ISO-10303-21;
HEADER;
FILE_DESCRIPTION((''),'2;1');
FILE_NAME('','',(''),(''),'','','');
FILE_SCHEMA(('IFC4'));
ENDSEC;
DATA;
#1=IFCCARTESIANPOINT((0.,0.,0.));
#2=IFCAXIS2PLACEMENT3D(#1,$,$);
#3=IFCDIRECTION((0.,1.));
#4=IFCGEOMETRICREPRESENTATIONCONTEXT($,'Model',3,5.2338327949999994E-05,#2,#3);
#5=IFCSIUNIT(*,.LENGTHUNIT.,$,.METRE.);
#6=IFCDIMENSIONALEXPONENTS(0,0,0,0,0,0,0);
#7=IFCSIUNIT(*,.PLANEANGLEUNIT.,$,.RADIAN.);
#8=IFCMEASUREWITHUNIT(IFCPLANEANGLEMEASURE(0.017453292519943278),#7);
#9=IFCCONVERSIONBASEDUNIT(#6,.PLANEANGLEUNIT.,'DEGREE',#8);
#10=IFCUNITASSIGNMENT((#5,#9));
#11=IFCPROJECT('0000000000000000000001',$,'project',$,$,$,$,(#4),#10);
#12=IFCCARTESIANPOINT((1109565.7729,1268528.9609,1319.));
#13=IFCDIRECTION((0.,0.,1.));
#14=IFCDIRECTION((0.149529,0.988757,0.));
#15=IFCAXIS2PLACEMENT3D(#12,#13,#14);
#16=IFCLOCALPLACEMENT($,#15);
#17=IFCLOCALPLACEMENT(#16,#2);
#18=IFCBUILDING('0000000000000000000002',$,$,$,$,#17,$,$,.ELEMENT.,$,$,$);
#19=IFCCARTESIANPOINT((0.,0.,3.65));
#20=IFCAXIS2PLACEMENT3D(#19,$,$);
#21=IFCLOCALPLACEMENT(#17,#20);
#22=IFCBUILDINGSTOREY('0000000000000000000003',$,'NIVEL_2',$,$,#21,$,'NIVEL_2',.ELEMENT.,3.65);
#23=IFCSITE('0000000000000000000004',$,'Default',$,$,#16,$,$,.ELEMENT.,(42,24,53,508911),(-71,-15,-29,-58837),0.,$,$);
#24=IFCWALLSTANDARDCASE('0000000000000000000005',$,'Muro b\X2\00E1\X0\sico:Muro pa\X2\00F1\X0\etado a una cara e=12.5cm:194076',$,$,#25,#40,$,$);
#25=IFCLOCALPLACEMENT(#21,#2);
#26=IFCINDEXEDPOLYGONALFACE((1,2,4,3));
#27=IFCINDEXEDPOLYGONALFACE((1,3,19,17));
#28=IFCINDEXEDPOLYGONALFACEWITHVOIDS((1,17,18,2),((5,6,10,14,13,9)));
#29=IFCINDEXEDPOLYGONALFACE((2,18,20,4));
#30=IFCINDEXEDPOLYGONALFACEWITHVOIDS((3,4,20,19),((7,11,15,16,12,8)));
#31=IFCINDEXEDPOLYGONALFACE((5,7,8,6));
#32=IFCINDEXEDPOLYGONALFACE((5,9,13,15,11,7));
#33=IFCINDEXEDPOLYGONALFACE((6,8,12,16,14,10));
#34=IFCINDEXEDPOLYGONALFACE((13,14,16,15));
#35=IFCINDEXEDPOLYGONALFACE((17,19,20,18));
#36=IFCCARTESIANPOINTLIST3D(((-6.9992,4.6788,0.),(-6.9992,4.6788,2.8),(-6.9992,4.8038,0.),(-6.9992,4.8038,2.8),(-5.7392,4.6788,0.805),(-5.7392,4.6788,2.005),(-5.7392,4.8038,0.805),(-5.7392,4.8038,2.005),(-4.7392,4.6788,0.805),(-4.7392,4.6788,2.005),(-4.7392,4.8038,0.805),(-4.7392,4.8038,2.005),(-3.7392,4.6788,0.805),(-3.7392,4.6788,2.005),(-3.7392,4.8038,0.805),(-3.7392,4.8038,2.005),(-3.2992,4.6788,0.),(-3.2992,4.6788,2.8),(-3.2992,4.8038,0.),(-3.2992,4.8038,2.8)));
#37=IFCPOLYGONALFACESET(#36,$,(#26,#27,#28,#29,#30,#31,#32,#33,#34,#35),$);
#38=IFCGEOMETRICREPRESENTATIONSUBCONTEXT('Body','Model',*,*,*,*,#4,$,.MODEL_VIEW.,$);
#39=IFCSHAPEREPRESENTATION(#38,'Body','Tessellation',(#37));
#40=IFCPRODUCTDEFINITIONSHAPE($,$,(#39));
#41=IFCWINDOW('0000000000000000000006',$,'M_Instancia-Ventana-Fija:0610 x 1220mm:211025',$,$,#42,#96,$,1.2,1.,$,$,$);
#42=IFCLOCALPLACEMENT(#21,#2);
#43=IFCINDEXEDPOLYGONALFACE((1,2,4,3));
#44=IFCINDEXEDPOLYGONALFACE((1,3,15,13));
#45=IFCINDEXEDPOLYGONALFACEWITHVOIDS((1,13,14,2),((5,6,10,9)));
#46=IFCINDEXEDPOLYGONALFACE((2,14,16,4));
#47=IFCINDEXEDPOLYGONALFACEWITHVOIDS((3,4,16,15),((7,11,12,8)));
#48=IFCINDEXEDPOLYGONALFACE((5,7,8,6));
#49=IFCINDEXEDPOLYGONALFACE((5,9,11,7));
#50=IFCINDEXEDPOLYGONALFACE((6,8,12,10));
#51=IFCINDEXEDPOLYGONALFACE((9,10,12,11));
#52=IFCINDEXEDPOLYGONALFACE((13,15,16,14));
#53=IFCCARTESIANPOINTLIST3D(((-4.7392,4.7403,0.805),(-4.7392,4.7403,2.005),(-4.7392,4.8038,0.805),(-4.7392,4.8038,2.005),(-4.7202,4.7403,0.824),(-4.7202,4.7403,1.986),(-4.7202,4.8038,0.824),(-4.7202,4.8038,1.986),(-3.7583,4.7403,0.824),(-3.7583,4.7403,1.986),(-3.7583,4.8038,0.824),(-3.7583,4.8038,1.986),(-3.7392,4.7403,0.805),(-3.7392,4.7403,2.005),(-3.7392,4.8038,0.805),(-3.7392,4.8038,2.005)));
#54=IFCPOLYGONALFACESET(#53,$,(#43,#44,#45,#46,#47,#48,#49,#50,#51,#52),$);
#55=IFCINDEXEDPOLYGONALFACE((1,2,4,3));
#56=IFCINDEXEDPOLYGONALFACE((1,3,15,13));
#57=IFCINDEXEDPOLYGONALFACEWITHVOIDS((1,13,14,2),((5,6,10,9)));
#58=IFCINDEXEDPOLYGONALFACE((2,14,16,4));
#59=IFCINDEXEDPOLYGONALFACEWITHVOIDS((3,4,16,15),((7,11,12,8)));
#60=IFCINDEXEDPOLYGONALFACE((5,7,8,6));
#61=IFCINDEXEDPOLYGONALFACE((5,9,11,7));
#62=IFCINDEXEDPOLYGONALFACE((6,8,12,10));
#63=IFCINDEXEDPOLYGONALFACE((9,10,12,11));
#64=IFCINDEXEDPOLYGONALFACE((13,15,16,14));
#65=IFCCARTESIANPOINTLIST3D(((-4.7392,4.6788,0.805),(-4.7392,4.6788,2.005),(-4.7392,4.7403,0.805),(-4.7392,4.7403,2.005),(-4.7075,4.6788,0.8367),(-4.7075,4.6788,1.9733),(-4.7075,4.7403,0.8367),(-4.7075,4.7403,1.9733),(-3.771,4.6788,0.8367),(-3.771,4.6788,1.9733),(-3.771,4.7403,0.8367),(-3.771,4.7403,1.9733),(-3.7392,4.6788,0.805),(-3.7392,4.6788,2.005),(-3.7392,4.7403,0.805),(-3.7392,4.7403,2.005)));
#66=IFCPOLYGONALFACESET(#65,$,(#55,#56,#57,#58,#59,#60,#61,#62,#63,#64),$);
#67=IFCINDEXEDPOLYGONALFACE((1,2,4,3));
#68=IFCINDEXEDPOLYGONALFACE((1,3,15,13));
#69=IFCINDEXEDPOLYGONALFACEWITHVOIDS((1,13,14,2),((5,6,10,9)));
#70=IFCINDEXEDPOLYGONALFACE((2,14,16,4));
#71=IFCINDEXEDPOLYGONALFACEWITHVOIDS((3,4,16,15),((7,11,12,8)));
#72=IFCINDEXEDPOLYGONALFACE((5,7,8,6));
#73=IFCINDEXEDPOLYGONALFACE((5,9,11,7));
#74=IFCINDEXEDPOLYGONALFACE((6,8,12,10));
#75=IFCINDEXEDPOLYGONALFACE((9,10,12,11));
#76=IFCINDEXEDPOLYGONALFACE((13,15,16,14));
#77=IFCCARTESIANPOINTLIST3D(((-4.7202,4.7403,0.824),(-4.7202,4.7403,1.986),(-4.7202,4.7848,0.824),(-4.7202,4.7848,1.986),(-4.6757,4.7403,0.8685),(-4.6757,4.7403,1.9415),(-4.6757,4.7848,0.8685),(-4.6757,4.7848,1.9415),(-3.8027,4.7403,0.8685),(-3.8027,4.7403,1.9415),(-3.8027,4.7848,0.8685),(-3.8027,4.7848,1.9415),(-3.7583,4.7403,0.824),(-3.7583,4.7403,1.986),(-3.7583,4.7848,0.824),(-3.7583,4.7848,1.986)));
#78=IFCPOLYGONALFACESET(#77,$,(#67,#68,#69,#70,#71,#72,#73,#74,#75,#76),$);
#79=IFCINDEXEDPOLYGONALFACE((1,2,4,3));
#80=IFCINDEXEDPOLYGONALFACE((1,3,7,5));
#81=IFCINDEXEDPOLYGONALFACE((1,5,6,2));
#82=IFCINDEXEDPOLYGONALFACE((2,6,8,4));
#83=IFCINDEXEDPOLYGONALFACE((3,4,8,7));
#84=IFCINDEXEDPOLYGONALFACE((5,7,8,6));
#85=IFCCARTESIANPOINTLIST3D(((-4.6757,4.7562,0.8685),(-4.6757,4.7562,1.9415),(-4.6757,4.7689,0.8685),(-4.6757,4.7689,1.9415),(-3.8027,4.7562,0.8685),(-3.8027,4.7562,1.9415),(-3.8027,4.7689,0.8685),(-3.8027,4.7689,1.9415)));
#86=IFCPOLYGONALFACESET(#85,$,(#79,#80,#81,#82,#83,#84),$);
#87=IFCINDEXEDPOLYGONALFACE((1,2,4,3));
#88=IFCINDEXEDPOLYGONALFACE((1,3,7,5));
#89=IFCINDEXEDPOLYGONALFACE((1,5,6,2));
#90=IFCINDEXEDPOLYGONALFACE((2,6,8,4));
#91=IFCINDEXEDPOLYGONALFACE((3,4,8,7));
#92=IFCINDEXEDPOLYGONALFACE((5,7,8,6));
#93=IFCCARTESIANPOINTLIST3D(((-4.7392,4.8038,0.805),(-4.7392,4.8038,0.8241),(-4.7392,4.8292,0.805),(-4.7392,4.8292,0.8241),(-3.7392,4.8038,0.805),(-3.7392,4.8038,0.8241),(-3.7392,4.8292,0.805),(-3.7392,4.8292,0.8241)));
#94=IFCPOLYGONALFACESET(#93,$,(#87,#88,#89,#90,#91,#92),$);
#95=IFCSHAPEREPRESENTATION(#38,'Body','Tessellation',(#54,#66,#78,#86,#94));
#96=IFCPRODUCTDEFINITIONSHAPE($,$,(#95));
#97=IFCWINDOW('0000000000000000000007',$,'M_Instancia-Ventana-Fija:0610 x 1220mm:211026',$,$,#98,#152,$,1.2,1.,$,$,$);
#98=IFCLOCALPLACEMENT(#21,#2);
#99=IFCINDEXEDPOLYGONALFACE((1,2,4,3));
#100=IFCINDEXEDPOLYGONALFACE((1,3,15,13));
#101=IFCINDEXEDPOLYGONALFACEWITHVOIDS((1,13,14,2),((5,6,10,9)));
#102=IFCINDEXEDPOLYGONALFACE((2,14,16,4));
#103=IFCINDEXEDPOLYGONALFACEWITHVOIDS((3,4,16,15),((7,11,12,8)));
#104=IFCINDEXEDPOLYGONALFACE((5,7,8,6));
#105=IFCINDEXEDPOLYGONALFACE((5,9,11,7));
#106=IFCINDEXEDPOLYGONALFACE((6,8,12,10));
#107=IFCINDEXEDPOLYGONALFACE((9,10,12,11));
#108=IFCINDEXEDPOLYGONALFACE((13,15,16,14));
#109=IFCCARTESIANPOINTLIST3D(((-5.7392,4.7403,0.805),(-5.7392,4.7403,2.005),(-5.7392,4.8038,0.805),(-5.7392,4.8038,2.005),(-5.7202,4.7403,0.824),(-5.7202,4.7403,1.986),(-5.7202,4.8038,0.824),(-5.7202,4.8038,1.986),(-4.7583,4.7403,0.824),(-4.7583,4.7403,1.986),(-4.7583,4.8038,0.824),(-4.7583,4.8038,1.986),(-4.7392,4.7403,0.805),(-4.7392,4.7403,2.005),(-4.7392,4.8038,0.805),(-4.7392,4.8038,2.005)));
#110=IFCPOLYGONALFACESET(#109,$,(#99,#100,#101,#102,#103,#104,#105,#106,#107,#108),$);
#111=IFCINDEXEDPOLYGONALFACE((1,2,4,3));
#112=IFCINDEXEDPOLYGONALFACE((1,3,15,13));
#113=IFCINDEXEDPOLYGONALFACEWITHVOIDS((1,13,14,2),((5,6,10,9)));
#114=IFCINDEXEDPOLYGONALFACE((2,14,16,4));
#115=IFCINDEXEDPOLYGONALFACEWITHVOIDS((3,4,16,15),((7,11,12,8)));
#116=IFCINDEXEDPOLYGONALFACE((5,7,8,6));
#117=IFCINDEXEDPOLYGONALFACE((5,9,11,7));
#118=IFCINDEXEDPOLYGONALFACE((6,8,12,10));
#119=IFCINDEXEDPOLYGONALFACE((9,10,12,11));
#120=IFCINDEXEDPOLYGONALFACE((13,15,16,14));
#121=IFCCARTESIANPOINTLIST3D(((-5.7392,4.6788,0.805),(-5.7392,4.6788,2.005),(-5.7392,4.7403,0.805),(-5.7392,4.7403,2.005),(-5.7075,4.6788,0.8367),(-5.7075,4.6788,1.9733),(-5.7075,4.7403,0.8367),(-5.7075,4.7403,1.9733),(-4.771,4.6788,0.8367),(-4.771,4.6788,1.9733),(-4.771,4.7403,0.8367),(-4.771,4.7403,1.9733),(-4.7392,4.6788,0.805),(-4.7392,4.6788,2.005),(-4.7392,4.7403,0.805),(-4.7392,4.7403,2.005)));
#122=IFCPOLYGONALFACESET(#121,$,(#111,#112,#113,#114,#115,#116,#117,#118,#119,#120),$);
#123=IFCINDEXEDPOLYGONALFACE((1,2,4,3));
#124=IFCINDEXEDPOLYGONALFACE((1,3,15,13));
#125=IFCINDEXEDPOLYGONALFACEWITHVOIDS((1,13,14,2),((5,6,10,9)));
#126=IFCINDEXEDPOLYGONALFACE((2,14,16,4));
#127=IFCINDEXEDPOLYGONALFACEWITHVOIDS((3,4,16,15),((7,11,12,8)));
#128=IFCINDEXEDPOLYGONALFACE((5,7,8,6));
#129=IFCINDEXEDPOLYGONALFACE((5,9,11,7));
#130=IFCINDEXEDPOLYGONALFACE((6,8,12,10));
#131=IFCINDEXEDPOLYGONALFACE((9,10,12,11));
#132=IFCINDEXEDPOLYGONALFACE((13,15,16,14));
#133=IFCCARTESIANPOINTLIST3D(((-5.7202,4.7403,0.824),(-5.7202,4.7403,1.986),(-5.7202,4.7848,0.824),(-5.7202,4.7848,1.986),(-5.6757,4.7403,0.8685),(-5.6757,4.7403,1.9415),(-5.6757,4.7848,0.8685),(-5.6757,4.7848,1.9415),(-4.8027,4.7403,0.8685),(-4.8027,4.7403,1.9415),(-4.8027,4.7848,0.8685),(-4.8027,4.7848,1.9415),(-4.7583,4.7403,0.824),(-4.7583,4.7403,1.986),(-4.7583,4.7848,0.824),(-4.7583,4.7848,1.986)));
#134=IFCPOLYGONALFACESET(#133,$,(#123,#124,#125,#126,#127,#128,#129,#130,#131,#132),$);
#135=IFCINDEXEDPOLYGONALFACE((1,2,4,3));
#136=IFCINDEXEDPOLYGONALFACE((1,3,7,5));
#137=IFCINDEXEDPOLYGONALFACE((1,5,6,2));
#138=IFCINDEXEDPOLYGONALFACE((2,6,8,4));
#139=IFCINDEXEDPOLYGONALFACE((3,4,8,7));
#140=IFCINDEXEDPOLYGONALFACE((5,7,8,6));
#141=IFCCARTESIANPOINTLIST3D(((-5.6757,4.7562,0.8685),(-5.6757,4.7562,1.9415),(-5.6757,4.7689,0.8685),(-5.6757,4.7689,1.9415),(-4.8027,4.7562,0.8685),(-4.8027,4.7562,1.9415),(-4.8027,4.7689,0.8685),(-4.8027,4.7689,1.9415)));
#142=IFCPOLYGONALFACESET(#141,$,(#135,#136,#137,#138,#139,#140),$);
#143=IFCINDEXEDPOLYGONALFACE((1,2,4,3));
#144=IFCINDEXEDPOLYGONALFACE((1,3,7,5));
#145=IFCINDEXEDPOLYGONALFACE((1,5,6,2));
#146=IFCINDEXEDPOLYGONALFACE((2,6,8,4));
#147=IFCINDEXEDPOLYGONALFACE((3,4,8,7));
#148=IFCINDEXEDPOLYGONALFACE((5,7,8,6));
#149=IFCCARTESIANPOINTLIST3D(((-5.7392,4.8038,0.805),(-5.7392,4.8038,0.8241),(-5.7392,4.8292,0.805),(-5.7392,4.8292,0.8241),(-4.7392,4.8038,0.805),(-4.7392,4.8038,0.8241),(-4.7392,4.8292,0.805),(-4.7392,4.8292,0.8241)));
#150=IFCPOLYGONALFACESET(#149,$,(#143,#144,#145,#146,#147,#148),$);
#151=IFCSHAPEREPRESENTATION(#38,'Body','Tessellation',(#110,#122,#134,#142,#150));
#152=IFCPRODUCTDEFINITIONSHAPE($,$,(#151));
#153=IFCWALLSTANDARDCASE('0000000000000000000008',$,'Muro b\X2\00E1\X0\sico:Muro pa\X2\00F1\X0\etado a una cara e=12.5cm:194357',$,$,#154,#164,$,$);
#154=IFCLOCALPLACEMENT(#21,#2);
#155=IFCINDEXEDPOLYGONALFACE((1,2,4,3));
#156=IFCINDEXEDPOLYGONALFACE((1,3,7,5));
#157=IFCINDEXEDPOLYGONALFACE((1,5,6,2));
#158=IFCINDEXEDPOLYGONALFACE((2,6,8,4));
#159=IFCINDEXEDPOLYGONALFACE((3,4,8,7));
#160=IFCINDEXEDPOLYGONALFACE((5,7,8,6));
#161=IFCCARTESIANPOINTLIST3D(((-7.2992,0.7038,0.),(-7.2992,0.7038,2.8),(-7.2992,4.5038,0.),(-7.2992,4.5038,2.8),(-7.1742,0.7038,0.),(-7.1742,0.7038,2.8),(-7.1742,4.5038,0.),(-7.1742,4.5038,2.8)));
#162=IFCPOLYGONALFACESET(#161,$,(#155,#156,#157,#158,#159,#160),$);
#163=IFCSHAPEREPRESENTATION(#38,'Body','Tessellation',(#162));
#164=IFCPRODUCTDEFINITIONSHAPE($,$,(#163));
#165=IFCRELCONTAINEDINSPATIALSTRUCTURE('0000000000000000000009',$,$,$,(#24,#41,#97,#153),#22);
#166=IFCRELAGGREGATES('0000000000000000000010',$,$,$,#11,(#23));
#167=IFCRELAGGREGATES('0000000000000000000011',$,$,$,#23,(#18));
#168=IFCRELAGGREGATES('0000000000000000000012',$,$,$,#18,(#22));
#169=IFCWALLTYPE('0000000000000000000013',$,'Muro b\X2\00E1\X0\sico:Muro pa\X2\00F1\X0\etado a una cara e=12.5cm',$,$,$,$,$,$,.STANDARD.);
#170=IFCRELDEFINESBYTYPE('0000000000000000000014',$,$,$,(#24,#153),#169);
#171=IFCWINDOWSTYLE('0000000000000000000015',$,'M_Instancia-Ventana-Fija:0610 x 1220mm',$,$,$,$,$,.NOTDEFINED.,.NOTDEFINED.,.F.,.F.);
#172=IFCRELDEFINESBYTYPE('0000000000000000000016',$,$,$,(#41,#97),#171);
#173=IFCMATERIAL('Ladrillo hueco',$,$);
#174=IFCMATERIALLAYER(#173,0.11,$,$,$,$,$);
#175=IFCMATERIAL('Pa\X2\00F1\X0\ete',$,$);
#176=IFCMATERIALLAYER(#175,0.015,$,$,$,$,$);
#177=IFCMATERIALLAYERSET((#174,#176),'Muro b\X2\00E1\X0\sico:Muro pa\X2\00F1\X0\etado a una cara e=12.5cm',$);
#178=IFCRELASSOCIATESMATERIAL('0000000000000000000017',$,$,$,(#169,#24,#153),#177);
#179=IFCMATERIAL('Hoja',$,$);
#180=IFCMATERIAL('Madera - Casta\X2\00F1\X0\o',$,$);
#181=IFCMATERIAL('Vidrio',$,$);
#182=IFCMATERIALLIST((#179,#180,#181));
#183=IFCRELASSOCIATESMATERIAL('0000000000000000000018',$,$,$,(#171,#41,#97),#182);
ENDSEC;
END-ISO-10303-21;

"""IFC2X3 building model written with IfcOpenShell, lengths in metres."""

from ifc_helpers import new_model, entity, si_unit, converted_unit, direction, frame, frame_2d, origin, origin_2d_with_axis, place, context, subcontext, project, spatial, polyline, rectangle, outline, extrude, source, transform, mapped, material, material_list, layer, layer_set, layer_usage, type_object, type_shapes, element, fill, save


model = new_model("IFC2X3")

# Units and contexts
model_context = context("Model", 3, precision=5.2338327949999994e-05, world=origin(), true_north=direction((0.0, 1.0)))
body_context = subcontext(model_context, "Body", "Model", "MODEL_VIEW")
ifc_project = project(units=[si_unit("LENGTHUNIT", "METRE"), converted_unit("PLANEANGLEUNIT", "DEGREE", entity("IfcPlaneAngleMeasure", 0.017453292519943278), si_unit("PLANEANGLEUNIT", "RADIAN"), dimensions=[0, 0, 0, 0, 0, 0, 0])], contexts=[model_context])

# Site, building, storey
site_placement = place(None, frame((1109565.7729, 1268528.9609, 1319.0), z_axis=(0.0, 0.0, 1.0), x_axis=(0.149529, 0.988757, 0.0)))
site = spatial("IfcSite", under=ifc_project, at=site_placement, Name="Default", CompositionType="ELEMENT", RefLatitude=(42, 24, 53, 508911), RefLongitude=(-71, -15, -29, -58837), RefElevation=0.0)
building_placement = place(site_placement, origin())
building = spatial("IfcBuilding", under=site, at=building_placement, CompositionType="ELEMENT")
storey_placement = place(building_placement, frame((0.0, 0.0, 3.65)))
storey = spatial("IfcBuildingStorey", under=building, at=storey_placement, Name="NIVEL_2", LongName="NIVEL_2", CompositionType="ELEMENT", Elevation=3.65)

# Shared definitions
ifc_material_1 = material(Name="Pañete")
ifc_material_2 = material(Name="Ladrillo hueco")

# Wall, openings, windows
ifc_layer_1 = layer(ifc_material_2, 0.11)
ifc_layer_2 = layer(ifc_material_1, 0.015)
ifc_layer_set_1 = layer_set([ifc_layer_1, ifc_layer_2], Name="Muro básico:Muro pañetado a una cara e=12.5cm")
ifc_layer_usage_1 = layer_usage(ifc_layer_set_1, "AXIS2", "NEGATIVE", 0.0625)
wall_type_1 = type_object("IfcWallType", Name="Muro básico:Muro pañetado a una cara e=12.5cm", PredefinedType="STANDARD", material=ifc_layer_set_1)
wall_1_placement = place(storey_placement, frame((-6.9992, 4.7413, 0.0)))
wall_1 = element("IfcWallStandardCase", 1, at=wall_1_placement, inside=storey, type_object=wall_type_1, material=ifc_layer_usage_1, Name="Muro básico:Muro pañetado a una cara e=12.5cm:194076", context=body_context, shape_type="SweptSolid", body=[
    extrude(rectangle(XDim=3.7, YDim=0.125, at=frame_2d((1.85, 0.0), x_axis=(-1.0, 0.0))), origin(), (0.0, 0.0, 1.0), 2.8),
])
opening_1_placement = place(wall_1_placement, frame((1.26, -0.0625, 0.805)))
opening_1 = element("IfcOpeningElement", 2, at=opening_1_placement, cuts=wall_1, ObjectType="Opening", context=body_context, shape_type="SweptSolid", body=[
    extrude(rectangle(XDim=1.2, YDim=1.0, at=frame_2d((0.6, 0.5), x_axis=(-1.0, 0.0))), frame((0.0, 0.0, 0.0), z_axis=(0.0, 1.0, 0.0), x_axis=(0.0, 0.0, 1.0)), (0.0, 0.0, 1.0), 0.125),
])
opening_2_placement = place(wall_1_placement, frame((2.26, -0.0625, 0.805)))
opening_2 = element("IfcOpeningElement", 3, at=opening_2_placement, cuts=wall_1, ObjectType="Opening", context=body_context, shape_type="SweptSolid", body=[
    extrude(rectangle(XDim=1.2, YDim=1.0, at=frame_2d((0.6, 0.5), x_axis=(-1.0, 0.0))), frame((0.0, 0.0, 0.0), z_axis=(0.0, 1.0, 0.0), x_axis=(0.0, 0.0, 1.0)), (0.0, 0.0, 1.0), 0.125),
])
ifc_material_3 = material(Name="Hoja")
ifc_material_4 = material(Name="Madera - Castaño")
ifc_material_5 = material(Name="Vidrio")
ifc_material_list = material_list([ifc_material_3, ifc_material_4, ifc_material_5])
window_style_1 = type_object("IfcWindowStyle", Name="M_Instancia-Ventana-Fija:0610 x 1220mm", ConstructionType="NOTDEFINED", OperationType="NOTDEFINED", ParameterTakesPrecedence=False, Sizeable=False, material=ifc_material_list)
shared_shape_1 = source(origin(), body_context, "Body", "SweptSolid", [
    extrude(outline(polyline([(-0.6, -0.5), (0.6, -0.5), (0.6, 0.5), (-0.6, 0.5), (-0.6, -0.5)]), holes=[polyline([(-0.5809, -0.4809), (-0.5809, 0.481), (0.581, 0.481), (0.581, -0.4809), (-0.5809, -0.4809)])]), frame((0.5, 0.0616, 0.6), z_axis=(0.0, 1.0, 0.0), x_axis=(0.0, 0.0, -1.0)), (0.0, 0.0, 1.0), 0.0635),
    extrude(outline(polyline([(-0.5, -0.6), (0.5, -0.6), (0.5, 0.6), (-0.5, 0.6), (-0.5, -0.6)]), holes=[polyline([(-0.4683, -0.5682), (-0.4683, 0.5683), (0.4682, 0.5683), (0.4682, -0.5682), (-0.4683, -0.5682)])]), frame((0.5, 0.0, 0.6), z_axis=(0.0, 1.0, 0.0), x_axis=(1.0, 0.0, 0.0)), (0.0, 0.0, 1.0), 0.0616),
    extrude(outline(polyline([(-0.4809, -0.581), (0.4809, -0.581), (0.4809, 0.581), (-0.4809, 0.581), (-0.4809, -0.581)]), holes=[polyline([(-0.4365, -0.5365), (-0.4365, 0.5365), (0.4365, 0.5365), (0.4365, -0.5365), (-0.4365, -0.5365)])]), frame((0.5, 0.0616, 0.6), z_axis=(0.0, 1.0, 0.0), x_axis=(1.0, 0.0, 0.0)), (0.0, 0.0, 1.0), 0.0444),
    extrude(rectangle(XDim=0.0127, YDim=0.873, at=origin_2d_with_axis()), frame((0.5, 0.0838, 0.0635), z_axis=(0.0, 0.0, 1.0), x_axis=(0.0, 1.0, 0.0)), (0.0, 0.0, 1.0), 1.073),
    extrude(rectangle(XDim=0.0254, YDim=1.0, at=origin_2d_with_axis()), frame((0.5, 0.1377, 0.0), z_axis=(0.0, 0.0, 1.0), x_axis=(0.0, -1.0, 0.0)), (0.0, 0.0, 1.0), 0.019),
])
type_shapes(window_style_1, [shared_shape_1])
window_1_placement = place(opening_2_placement, origin())
window_1 = element("IfcWindow", 4, at=window_1_placement, inside=storey, type_object=window_style_1, material=ifc_material_list, Name="M_Instancia-Ventana-Fija:0610 x 1220mm:211025", OverallHeight=1.2, OverallWidth=1.0, context=body_context, shape_type="MappedRepresentation", body=[
    mapped(shared_shape_1, transform((0.0, 0.0, 0.0), scale=1.0)),
])
fill(opening_2, window_1)
window_2_placement = place(opening_1_placement, origin())
window_2 = element("IfcWindow", 5, at=window_2_placement, inside=storey, type_object=window_style_1, material=ifc_material_list, Name="M_Instancia-Ventana-Fija:0610 x 1220mm:211026", OverallHeight=1.2, OverallWidth=1.0, context=body_context, shape_type="MappedRepresentation", body=[
    mapped(shared_shape_1, transform((0.0, 0.0, 0.0), scale=1.0)),
])
fill(opening_1, window_2)

# Wall
ifc_layer_usage_2 = layer_usage(ifc_layer_set_1, "AXIS2", "POSITIVE", -0.0625)
wall_2_placement = place(storey_placement, frame((-7.2367, 4.5038, 0.0), z_axis=(0.0, 0.0, 1.0), x_axis=(0.0, -1.0, 0.0)))
element("IfcWallStandardCase", 6, at=wall_2_placement, inside=storey, type_object=wall_type_1, material=ifc_layer_usage_2, Name="Muro básico:Muro pañetado a una cara e=12.5cm:194357", context=body_context, shape_type="SweptSolid", body=[
    extrude(rectangle(XDim=3.8, YDim=0.125, at=frame_2d((1.9, 0.0), x_axis=(-1.0, 0.0))), origin(), (0.0, 0.0, 1.0), 2.8),
])

save(model, "model.ifc")
